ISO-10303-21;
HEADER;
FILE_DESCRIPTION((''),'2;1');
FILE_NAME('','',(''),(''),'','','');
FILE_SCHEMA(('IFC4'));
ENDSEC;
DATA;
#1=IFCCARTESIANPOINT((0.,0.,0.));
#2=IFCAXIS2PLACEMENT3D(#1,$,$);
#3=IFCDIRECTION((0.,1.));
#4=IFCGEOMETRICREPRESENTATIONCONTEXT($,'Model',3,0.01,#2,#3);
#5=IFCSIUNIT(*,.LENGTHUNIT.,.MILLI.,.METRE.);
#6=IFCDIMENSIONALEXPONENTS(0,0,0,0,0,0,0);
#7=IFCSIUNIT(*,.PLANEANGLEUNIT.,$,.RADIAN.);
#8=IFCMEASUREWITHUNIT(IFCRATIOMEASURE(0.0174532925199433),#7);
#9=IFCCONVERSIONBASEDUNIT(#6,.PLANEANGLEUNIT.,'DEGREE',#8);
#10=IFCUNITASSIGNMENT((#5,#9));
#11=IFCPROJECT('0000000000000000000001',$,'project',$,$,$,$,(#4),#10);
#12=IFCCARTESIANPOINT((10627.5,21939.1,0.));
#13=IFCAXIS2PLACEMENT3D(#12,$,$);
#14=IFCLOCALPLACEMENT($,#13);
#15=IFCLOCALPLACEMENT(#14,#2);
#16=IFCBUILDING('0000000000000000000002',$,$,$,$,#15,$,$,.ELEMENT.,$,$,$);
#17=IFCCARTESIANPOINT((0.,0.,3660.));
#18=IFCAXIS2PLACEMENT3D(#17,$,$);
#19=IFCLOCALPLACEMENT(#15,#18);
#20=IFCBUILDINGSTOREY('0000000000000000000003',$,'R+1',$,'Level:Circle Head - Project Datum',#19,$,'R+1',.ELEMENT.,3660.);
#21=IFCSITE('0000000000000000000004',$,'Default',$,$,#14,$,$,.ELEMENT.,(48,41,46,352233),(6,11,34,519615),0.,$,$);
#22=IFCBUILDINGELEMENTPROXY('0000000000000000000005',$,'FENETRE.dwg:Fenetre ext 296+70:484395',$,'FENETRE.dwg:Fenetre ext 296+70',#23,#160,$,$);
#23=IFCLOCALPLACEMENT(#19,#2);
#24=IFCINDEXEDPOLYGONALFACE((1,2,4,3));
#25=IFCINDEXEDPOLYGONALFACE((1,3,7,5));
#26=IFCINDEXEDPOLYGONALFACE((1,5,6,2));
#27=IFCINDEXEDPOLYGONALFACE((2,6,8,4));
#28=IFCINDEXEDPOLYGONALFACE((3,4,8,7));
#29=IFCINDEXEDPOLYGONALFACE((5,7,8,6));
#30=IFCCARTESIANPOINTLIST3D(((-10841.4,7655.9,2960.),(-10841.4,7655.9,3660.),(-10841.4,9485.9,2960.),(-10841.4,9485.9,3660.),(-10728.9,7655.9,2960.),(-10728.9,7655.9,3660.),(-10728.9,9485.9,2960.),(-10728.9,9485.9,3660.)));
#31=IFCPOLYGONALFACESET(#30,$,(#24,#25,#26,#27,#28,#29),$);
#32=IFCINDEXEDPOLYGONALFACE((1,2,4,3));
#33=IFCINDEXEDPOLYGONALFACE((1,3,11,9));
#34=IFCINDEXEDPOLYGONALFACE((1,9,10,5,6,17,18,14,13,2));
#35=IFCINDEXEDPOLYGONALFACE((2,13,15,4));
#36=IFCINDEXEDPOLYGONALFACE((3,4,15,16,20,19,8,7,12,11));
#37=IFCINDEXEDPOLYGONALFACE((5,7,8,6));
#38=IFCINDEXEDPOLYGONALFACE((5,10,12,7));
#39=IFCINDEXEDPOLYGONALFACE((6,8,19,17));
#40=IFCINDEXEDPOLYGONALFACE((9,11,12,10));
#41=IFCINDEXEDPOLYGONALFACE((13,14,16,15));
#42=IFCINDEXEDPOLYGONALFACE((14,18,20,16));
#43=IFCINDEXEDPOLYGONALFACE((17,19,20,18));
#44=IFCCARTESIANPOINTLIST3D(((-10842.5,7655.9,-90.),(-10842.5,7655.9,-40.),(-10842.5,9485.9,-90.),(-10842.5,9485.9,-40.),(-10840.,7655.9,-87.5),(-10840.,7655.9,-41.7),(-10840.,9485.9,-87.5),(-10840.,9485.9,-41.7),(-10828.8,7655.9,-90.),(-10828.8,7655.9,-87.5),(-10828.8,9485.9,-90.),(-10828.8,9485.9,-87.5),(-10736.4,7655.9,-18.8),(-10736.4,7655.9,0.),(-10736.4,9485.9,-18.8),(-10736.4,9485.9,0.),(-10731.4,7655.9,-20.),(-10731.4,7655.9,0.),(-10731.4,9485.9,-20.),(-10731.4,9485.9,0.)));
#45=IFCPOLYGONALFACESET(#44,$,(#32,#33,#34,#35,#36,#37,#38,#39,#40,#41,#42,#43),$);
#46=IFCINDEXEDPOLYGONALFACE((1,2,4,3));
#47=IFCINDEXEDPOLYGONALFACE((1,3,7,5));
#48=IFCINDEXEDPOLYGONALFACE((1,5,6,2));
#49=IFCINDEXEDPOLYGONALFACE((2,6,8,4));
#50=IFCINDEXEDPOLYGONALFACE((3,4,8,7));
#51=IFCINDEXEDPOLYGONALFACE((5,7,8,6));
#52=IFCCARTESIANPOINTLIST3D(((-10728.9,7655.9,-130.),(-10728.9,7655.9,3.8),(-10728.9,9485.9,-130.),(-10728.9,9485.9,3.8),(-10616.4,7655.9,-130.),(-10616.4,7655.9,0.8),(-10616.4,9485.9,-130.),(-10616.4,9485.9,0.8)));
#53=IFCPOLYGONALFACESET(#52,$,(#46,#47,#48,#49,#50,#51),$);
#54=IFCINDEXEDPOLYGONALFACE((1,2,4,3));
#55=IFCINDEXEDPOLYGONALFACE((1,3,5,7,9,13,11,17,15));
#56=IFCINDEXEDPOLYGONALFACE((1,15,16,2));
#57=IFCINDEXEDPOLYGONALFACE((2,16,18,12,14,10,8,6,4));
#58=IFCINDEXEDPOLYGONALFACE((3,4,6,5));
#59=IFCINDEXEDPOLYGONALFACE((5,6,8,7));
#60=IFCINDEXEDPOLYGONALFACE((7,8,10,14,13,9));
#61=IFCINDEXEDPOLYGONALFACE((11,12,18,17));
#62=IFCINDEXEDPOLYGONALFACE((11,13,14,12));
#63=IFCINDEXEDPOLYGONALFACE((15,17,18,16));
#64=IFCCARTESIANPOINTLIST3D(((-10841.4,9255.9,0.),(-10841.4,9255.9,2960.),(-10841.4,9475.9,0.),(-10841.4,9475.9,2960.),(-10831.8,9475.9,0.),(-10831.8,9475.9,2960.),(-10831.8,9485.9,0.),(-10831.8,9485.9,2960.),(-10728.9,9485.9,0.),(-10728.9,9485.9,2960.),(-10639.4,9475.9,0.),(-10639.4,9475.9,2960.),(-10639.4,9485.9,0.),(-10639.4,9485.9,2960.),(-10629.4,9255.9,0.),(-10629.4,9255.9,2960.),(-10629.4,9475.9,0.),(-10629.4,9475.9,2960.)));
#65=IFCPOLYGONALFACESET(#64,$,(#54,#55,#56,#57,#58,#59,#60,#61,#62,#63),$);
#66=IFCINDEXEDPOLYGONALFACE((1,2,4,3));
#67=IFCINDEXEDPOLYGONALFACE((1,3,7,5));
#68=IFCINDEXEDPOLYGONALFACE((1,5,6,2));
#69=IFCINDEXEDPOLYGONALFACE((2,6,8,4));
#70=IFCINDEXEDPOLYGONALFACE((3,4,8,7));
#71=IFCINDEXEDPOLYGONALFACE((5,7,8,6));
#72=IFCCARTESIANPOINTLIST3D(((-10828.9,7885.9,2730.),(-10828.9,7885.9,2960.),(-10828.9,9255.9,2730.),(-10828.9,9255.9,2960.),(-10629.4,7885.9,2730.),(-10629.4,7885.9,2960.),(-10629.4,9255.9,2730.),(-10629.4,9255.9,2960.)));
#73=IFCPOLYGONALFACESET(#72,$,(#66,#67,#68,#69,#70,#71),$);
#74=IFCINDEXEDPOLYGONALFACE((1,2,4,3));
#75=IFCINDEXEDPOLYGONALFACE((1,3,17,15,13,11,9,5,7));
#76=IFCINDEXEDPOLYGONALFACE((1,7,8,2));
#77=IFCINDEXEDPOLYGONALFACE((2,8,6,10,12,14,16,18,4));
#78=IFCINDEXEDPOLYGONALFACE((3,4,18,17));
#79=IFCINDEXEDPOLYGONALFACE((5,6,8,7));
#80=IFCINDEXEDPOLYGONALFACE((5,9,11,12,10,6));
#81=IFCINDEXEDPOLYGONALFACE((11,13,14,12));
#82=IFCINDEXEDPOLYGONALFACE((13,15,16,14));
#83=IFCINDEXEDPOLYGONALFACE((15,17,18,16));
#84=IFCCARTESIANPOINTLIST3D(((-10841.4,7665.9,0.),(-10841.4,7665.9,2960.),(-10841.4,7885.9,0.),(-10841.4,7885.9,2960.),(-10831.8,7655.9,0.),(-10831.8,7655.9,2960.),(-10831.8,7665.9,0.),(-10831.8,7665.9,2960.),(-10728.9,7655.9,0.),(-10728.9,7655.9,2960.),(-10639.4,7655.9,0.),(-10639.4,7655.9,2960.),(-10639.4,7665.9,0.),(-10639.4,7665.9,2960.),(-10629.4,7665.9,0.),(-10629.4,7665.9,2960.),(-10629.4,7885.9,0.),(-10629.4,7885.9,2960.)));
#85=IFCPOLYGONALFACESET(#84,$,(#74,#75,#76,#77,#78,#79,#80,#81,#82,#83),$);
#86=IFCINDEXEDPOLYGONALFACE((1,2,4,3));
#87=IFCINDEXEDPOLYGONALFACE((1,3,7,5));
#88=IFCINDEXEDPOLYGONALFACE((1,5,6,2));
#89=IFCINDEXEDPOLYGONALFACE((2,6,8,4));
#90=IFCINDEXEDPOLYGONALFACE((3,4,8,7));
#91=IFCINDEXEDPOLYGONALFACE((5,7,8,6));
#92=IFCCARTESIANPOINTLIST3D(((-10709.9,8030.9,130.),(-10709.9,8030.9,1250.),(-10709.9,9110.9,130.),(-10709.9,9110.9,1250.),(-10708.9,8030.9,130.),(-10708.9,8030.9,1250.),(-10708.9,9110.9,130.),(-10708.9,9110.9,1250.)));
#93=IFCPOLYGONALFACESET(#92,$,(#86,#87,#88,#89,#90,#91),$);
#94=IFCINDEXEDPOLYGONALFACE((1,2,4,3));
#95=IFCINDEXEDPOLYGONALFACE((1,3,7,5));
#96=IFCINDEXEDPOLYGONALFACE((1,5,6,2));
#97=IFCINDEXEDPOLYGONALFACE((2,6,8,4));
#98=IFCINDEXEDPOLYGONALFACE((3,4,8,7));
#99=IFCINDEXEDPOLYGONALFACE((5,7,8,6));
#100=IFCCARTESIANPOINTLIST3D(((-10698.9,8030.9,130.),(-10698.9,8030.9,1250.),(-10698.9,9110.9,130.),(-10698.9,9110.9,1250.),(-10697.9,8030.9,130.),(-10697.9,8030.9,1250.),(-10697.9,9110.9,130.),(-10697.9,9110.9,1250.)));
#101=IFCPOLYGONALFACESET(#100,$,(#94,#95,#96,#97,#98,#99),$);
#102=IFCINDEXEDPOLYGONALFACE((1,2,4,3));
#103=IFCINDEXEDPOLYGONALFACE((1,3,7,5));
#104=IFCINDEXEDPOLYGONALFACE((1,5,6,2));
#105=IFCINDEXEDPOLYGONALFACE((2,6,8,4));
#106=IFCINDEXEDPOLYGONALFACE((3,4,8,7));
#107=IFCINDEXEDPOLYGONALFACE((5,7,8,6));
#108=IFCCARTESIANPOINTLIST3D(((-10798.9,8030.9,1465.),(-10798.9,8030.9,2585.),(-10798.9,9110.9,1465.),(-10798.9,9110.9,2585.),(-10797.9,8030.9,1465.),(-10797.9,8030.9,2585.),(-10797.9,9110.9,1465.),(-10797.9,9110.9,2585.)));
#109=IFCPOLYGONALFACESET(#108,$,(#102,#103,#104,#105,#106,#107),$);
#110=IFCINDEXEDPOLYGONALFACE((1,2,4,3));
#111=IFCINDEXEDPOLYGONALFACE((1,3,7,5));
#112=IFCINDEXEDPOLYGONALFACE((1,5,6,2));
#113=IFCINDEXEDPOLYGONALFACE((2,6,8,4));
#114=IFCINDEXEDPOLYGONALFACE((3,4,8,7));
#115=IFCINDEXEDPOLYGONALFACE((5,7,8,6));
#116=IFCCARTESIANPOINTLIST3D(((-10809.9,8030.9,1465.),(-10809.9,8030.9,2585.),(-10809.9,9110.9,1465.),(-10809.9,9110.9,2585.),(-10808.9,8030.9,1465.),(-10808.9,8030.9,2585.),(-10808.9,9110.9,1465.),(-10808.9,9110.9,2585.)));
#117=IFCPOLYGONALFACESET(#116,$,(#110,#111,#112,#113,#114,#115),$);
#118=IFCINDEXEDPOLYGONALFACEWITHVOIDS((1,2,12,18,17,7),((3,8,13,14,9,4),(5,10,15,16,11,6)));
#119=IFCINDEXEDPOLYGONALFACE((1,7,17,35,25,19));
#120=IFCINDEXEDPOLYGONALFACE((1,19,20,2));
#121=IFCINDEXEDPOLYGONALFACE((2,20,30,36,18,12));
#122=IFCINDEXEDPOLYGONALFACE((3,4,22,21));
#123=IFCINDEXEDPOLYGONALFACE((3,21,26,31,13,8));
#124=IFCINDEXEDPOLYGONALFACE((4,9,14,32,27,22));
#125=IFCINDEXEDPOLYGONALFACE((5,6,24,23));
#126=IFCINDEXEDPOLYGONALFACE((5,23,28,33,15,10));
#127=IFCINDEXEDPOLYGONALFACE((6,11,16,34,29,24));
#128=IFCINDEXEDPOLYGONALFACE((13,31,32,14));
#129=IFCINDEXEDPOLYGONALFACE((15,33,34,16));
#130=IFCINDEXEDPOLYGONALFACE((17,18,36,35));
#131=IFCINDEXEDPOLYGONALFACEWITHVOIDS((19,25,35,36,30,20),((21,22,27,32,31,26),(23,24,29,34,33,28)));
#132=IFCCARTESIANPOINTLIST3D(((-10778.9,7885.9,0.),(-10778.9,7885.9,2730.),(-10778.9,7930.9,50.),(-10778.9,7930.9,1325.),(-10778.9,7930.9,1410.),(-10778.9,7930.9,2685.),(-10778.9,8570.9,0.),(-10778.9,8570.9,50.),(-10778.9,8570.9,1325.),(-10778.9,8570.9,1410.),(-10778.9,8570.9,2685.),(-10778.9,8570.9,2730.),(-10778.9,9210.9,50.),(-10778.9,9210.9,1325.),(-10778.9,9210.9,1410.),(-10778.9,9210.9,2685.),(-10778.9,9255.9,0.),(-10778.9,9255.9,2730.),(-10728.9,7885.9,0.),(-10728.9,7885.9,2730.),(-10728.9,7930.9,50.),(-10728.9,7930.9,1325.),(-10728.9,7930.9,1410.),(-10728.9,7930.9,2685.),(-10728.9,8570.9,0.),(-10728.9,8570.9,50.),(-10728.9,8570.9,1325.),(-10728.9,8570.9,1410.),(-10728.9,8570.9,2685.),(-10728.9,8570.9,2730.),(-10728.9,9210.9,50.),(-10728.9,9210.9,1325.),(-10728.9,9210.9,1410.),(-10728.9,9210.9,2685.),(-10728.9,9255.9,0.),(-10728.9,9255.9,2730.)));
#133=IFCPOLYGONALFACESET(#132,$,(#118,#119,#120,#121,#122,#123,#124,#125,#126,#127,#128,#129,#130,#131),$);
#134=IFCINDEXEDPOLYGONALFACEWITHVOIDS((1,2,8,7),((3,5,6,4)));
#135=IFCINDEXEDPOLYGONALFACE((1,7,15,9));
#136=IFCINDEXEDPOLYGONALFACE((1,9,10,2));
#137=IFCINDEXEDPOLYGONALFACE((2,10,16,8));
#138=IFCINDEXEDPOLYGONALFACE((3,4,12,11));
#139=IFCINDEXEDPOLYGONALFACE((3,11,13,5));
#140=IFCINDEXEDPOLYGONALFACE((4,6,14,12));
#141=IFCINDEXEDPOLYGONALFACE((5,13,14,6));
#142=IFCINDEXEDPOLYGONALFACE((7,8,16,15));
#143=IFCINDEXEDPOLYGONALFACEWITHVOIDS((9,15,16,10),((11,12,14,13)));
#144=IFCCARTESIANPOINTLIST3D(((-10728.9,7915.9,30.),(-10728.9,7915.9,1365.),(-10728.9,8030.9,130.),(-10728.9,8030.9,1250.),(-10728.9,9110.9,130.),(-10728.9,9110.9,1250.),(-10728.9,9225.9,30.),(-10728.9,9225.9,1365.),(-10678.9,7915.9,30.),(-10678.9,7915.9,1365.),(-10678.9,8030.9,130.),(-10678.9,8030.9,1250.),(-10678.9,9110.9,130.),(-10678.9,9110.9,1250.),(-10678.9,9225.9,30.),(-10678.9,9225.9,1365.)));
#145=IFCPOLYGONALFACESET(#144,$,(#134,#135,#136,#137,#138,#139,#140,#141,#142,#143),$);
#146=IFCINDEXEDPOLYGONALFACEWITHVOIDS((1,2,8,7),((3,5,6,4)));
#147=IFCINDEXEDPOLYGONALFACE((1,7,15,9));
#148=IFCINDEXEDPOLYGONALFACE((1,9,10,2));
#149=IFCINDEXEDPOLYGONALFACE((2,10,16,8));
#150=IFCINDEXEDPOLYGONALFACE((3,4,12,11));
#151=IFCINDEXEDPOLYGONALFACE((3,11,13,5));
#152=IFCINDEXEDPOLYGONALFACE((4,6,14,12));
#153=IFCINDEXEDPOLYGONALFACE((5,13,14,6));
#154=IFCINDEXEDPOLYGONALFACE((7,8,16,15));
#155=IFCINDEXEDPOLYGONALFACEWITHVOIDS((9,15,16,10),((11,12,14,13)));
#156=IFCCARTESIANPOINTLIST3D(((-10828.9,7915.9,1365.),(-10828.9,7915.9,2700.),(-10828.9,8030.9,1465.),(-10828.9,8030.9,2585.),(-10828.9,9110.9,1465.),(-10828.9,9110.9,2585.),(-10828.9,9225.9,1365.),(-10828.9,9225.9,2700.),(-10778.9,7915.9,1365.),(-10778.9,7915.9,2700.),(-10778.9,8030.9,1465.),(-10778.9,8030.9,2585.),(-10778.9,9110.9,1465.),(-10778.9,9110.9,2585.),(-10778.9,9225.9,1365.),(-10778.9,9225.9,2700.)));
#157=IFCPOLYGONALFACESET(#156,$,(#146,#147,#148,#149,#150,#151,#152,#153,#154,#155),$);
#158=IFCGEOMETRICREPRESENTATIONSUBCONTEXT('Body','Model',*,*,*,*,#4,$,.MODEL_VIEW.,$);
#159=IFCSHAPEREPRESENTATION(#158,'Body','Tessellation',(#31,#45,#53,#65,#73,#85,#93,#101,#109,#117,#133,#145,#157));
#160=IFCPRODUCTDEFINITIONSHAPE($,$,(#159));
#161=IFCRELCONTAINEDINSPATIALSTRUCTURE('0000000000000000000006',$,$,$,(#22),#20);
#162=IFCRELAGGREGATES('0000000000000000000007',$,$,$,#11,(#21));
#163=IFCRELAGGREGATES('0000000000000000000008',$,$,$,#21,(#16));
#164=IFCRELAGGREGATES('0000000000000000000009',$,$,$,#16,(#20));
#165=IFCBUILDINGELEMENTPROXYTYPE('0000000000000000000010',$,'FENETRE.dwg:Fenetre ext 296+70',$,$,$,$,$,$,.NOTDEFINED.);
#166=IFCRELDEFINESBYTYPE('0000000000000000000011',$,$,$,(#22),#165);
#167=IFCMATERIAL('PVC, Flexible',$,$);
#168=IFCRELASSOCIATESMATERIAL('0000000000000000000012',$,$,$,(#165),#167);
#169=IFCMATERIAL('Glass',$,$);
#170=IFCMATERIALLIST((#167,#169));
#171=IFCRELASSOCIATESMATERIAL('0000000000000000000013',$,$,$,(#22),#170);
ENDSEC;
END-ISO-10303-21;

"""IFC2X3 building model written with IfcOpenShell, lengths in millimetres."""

from ifc_helpers import new_model, entity, si_unit, converted_unit, direction, frame, frame_2d, origin, origin_2d_with_axis, place, context, subcontext, project, spatial, polyline, rectangle, outline, extrude, source, transform, mapped, material, material_list, type_object, type_shapes, element, save


model = new_model("IFC2X3")

# Units and contexts
model_context = context("Model", 3, precision=0.01, world=origin(), true_north=direction((0.0, 1.0)))
body_context = subcontext(model_context, "Body", "Model", "MODEL_VIEW")
ifc_project = project(units=[si_unit("LENGTHUNIT", "METRE", prefix="MILLI"), converted_unit("PLANEANGLEUNIT", "DEGREE", entity("IfcRatioMeasure", 0.0174532925199433), si_unit("PLANEANGLEUNIT", "RADIAN"), dimensions=[0, 0, 0, 0, 0, 0, 0])], contexts=[model_context])

# Site, building, storey
site_placement = place(None, frame((10627.5, 21939.1, 0.0)))
site = spatial("IfcSite", under=ifc_project, at=site_placement, Name="Default", CompositionType="ELEMENT", RefLatitude=(48, 41, 46, 352233), RefLongitude=(6, 11, 34, 519615), RefElevation=0.0)
building_placement = place(site_placement, origin())
building = spatial("IfcBuilding", under=site, at=building_placement, CompositionType="ELEMENT")
storey_placement = place(building_placement, frame((0.0, 0.0, 3660.0)))
storey = spatial("IfcBuildingStorey", under=building, at=storey_placement, Name="R+1", ObjectType="Level:Circle Head - Project Datum", LongName="R+1", CompositionType="ELEMENT", Elevation=3660.0)

# Building element proxy
ifc_material_1 = material(Name="PVC, Flexible")
ifc_material_2 = material(Name="Glass")
building_element_proxy_type_1 = type_object("IfcBuildingElementProxyType", Name="FENETRE.dwg:Fenetre ext 296+70", PredefinedType="NOTDEFINED", material=ifc_material_1)
shared_shape_1 = source(origin(), body_context, "Body", "SweptSolid", [
    extrude(rectangle(XDim=1830.0, YDim=112.5, at=origin_2d_with_axis()), frame((-10.4, 56.3, 2960.0), z_axis=(0.0, 0.0, 1.0), x_axis=(-1.0, 0.0, 0.0)), (0.0, 0.0, 1.0), 700.0),
    extrude(outline(polyline([(-68.6, -14.4), (-72.5, -34.0), (-67.6, -35.0), (-63.9, -16.6), (44.3, -16.6), (54.1, 32.5), (40.6, 35.2), (40.1, 32.7), (51.2, 30.5), (42.2, -14.4), (-68.6, -14.4)])), frame((-925.4, 66.9, -47.5), z_axis=(-1.0, 0.0, 0.0), x_axis=(0.0, 0.980599, -0.196027)), (0.0, 0.0, -1.0), 1830.0),
    extrude(outline(polyline([(-64.7, -56.3), (66.2, -56.3), (66.2, 56.3), (-67.7, 56.3), (-64.7, -56.3)])), frame((-925.4, -56.3, -63.8), z_axis=(1.0, 0.0, 0.0), x_axis=(0.0, 0.0, -1.0)), (0.0, 0.0, 1.0), 1830.0),
    extrude(outline(polyline([(-55.6, 97.0), (-55.6, -5.9), (-55.6, -95.4), (-45.6, -95.4), (-45.6, -105.4), (174.4, -105.4), (174.4, 106.6), (-45.6, 106.6), (-45.6, 97.0), (-55.6, 97.0)])), frame((849.0, 5.9, 0.0), z_axis=(0.0, 0.0, -1.0), x_axis=(-1.0, 0.0, 0.0)), (0.0, 0.0, -1.0), 2960.0),
    extrude(rectangle(XDim=199.5, YDim=1370.0, at=origin_2d_with_axis()), frame((-10.4, 0.3, 2730.0), z_axis=(0.0, 0.0, 1.0), x_axis=(0.0, 1.0, 0.0)), (0.0, 0.0, 1.0), 230.0),
    extrude(outline(polyline([(-97.0, -55.6), (5.9, -55.6), (95.4, -55.6), (95.4, -45.6), (105.4, -45.6), (105.4, 174.4), (-106.6, 174.4), (-106.6, -45.6), (-97.0, -45.6), (-97.0, -55.6)])), frame((-869.9, 5.9, 0.0), z_axis=(0.0, 0.0, 1.0), x_axis=(0.0, -1.0, 0.0)), (0.0, 0.0, 1.0), 2960.0),
    extrude(rectangle(XDim=1.0, YDim=1080.0, at=origin_2d_with_axis()), frame((-10.4, -19.5, 130.0), z_axis=(0.0, 0.0, 1.0), x_axis=(0.0, 1.0, 0.0)), (0.0, 0.0, 1.0), 1120.0),
    extrude(rectangle(XDim=1.0, YDim=1080.0, at=frame_2d((0.0, 0.0), x_axis=(1.0, 0.0))), frame((-10.4, -30.5, 130.0), z_axis=(0.0, 0.0, 1.0), x_axis=(0.0, 1.0, 0.0)), (0.0, 0.0, 1.0), 1120.0),
    extrude(rectangle(XDim=1.0, YDim=1080.0, at=frame_2d((0.0, 0.0), x_axis=(1.0, 0.0))), frame((-10.4, 69.5, 1465.0), z_axis=(0.0, 0.0, 1.0), x_axis=(0.0, 1.0, 0.0)), (0.0, 0.0, 1.0), 1120.0),
    extrude(rectangle(XDim=1.0, YDim=1080.0, at=frame_2d((0.0, 0.0), x_axis=(1.0, 0.0))), frame((-10.4, 80.5, 1465.0), z_axis=(0.0, 0.0, 1.0), x_axis=(0.0, 1.0, 0.0)), (0.0, 0.0, 1.0), 1120.0),
    extrude(outline(polyline([(-685.0, -1365.0), (0.0, -1365.0), (685.0, -1365.0), (685.0, 1365.0), (0.0, 1365.0), (-685.0, 1365.0), (-685.0, -1365.0)]), holes=[polyline([(-640.0, -1320.0), (-640.0, -45.0), (0.0, -45.0), (640.0, -45.0), (640.0, -1320.0), (0.0, -1320.0), (-640.0, -1320.0)]), polyline([(-640.0, 40.0), (-640.0, 1315.0), (0.0, 1315.0), (640.0, 1315.0), (640.0, 40.0), (0.0, 40.0), (-640.0, 40.0)])]), frame((-10.4, 0.0, 1365.0), z_axis=(0.0, 1.0, 0.0), x_axis=(1.0, 0.0, 0.0)), (0.0, 0.0, 1.0), 50.0),
    extrude(outline(polyline([(-655.0, -667.5), (655.0, -667.5), (655.0, 667.5), (-655.0, 667.5), (-655.0, -667.5)]), holes=[polyline([(-540.0, 552.5), (540.0, 552.5), (540.0, -567.5), (-540.0, -567.5), (-540.0, 552.5)])]), frame((-10.4, -50.0, 697.5), z_axis=(0.0, 1.0, 0.0), x_axis=(-1.0, 0.0, 0.0)), (0.0, 0.0, 1.0), 50.0),
    extrude(outline(polyline([(-655.0, -667.5), (655.0, -667.5), (655.0, 667.5), (-655.0, 667.5), (-655.0, -667.5)]), holes=[polyline([(-540.0, 552.5), (540.0, 552.5), (540.0, -567.5), (-540.0, -567.5), (-540.0, 552.5)])]), frame((-10.4, 50.0, 2032.5), z_axis=(0.0, 1.0, 0.0), x_axis=(-1.0, 0.0, 0.0)), (0.0, 0.0, 1.0), 50.0),
])
type_shapes(building_element_proxy_type_1, [shared_shape_1])
ifc_material_list_1 = material_list([ifc_material_1, ifc_material_2])
proxy_1_placement = place(storey_placement, frame((-10728.9, 8581.3, 0.0), z_axis=(0.0, 0.0, 1.0), x_axis=(0.0, 1.0, 0.0)))
element("IfcBuildingElementProxy", 1, at=proxy_1_placement, inside=storey, type_object=building_element_proxy_type_1, material=ifc_material_list_1, Name="FENETRE.dwg:Fenetre ext 296+70:484395", ObjectType="FENETRE.dwg:Fenetre ext 296+70", context=body_context, shape_type="MappedRepresentation", body=[
    mapped(shared_shape_1, transform((0.0, 0.0, 0.0), scale=1.0)),
])

save(model, "model.ifc")
